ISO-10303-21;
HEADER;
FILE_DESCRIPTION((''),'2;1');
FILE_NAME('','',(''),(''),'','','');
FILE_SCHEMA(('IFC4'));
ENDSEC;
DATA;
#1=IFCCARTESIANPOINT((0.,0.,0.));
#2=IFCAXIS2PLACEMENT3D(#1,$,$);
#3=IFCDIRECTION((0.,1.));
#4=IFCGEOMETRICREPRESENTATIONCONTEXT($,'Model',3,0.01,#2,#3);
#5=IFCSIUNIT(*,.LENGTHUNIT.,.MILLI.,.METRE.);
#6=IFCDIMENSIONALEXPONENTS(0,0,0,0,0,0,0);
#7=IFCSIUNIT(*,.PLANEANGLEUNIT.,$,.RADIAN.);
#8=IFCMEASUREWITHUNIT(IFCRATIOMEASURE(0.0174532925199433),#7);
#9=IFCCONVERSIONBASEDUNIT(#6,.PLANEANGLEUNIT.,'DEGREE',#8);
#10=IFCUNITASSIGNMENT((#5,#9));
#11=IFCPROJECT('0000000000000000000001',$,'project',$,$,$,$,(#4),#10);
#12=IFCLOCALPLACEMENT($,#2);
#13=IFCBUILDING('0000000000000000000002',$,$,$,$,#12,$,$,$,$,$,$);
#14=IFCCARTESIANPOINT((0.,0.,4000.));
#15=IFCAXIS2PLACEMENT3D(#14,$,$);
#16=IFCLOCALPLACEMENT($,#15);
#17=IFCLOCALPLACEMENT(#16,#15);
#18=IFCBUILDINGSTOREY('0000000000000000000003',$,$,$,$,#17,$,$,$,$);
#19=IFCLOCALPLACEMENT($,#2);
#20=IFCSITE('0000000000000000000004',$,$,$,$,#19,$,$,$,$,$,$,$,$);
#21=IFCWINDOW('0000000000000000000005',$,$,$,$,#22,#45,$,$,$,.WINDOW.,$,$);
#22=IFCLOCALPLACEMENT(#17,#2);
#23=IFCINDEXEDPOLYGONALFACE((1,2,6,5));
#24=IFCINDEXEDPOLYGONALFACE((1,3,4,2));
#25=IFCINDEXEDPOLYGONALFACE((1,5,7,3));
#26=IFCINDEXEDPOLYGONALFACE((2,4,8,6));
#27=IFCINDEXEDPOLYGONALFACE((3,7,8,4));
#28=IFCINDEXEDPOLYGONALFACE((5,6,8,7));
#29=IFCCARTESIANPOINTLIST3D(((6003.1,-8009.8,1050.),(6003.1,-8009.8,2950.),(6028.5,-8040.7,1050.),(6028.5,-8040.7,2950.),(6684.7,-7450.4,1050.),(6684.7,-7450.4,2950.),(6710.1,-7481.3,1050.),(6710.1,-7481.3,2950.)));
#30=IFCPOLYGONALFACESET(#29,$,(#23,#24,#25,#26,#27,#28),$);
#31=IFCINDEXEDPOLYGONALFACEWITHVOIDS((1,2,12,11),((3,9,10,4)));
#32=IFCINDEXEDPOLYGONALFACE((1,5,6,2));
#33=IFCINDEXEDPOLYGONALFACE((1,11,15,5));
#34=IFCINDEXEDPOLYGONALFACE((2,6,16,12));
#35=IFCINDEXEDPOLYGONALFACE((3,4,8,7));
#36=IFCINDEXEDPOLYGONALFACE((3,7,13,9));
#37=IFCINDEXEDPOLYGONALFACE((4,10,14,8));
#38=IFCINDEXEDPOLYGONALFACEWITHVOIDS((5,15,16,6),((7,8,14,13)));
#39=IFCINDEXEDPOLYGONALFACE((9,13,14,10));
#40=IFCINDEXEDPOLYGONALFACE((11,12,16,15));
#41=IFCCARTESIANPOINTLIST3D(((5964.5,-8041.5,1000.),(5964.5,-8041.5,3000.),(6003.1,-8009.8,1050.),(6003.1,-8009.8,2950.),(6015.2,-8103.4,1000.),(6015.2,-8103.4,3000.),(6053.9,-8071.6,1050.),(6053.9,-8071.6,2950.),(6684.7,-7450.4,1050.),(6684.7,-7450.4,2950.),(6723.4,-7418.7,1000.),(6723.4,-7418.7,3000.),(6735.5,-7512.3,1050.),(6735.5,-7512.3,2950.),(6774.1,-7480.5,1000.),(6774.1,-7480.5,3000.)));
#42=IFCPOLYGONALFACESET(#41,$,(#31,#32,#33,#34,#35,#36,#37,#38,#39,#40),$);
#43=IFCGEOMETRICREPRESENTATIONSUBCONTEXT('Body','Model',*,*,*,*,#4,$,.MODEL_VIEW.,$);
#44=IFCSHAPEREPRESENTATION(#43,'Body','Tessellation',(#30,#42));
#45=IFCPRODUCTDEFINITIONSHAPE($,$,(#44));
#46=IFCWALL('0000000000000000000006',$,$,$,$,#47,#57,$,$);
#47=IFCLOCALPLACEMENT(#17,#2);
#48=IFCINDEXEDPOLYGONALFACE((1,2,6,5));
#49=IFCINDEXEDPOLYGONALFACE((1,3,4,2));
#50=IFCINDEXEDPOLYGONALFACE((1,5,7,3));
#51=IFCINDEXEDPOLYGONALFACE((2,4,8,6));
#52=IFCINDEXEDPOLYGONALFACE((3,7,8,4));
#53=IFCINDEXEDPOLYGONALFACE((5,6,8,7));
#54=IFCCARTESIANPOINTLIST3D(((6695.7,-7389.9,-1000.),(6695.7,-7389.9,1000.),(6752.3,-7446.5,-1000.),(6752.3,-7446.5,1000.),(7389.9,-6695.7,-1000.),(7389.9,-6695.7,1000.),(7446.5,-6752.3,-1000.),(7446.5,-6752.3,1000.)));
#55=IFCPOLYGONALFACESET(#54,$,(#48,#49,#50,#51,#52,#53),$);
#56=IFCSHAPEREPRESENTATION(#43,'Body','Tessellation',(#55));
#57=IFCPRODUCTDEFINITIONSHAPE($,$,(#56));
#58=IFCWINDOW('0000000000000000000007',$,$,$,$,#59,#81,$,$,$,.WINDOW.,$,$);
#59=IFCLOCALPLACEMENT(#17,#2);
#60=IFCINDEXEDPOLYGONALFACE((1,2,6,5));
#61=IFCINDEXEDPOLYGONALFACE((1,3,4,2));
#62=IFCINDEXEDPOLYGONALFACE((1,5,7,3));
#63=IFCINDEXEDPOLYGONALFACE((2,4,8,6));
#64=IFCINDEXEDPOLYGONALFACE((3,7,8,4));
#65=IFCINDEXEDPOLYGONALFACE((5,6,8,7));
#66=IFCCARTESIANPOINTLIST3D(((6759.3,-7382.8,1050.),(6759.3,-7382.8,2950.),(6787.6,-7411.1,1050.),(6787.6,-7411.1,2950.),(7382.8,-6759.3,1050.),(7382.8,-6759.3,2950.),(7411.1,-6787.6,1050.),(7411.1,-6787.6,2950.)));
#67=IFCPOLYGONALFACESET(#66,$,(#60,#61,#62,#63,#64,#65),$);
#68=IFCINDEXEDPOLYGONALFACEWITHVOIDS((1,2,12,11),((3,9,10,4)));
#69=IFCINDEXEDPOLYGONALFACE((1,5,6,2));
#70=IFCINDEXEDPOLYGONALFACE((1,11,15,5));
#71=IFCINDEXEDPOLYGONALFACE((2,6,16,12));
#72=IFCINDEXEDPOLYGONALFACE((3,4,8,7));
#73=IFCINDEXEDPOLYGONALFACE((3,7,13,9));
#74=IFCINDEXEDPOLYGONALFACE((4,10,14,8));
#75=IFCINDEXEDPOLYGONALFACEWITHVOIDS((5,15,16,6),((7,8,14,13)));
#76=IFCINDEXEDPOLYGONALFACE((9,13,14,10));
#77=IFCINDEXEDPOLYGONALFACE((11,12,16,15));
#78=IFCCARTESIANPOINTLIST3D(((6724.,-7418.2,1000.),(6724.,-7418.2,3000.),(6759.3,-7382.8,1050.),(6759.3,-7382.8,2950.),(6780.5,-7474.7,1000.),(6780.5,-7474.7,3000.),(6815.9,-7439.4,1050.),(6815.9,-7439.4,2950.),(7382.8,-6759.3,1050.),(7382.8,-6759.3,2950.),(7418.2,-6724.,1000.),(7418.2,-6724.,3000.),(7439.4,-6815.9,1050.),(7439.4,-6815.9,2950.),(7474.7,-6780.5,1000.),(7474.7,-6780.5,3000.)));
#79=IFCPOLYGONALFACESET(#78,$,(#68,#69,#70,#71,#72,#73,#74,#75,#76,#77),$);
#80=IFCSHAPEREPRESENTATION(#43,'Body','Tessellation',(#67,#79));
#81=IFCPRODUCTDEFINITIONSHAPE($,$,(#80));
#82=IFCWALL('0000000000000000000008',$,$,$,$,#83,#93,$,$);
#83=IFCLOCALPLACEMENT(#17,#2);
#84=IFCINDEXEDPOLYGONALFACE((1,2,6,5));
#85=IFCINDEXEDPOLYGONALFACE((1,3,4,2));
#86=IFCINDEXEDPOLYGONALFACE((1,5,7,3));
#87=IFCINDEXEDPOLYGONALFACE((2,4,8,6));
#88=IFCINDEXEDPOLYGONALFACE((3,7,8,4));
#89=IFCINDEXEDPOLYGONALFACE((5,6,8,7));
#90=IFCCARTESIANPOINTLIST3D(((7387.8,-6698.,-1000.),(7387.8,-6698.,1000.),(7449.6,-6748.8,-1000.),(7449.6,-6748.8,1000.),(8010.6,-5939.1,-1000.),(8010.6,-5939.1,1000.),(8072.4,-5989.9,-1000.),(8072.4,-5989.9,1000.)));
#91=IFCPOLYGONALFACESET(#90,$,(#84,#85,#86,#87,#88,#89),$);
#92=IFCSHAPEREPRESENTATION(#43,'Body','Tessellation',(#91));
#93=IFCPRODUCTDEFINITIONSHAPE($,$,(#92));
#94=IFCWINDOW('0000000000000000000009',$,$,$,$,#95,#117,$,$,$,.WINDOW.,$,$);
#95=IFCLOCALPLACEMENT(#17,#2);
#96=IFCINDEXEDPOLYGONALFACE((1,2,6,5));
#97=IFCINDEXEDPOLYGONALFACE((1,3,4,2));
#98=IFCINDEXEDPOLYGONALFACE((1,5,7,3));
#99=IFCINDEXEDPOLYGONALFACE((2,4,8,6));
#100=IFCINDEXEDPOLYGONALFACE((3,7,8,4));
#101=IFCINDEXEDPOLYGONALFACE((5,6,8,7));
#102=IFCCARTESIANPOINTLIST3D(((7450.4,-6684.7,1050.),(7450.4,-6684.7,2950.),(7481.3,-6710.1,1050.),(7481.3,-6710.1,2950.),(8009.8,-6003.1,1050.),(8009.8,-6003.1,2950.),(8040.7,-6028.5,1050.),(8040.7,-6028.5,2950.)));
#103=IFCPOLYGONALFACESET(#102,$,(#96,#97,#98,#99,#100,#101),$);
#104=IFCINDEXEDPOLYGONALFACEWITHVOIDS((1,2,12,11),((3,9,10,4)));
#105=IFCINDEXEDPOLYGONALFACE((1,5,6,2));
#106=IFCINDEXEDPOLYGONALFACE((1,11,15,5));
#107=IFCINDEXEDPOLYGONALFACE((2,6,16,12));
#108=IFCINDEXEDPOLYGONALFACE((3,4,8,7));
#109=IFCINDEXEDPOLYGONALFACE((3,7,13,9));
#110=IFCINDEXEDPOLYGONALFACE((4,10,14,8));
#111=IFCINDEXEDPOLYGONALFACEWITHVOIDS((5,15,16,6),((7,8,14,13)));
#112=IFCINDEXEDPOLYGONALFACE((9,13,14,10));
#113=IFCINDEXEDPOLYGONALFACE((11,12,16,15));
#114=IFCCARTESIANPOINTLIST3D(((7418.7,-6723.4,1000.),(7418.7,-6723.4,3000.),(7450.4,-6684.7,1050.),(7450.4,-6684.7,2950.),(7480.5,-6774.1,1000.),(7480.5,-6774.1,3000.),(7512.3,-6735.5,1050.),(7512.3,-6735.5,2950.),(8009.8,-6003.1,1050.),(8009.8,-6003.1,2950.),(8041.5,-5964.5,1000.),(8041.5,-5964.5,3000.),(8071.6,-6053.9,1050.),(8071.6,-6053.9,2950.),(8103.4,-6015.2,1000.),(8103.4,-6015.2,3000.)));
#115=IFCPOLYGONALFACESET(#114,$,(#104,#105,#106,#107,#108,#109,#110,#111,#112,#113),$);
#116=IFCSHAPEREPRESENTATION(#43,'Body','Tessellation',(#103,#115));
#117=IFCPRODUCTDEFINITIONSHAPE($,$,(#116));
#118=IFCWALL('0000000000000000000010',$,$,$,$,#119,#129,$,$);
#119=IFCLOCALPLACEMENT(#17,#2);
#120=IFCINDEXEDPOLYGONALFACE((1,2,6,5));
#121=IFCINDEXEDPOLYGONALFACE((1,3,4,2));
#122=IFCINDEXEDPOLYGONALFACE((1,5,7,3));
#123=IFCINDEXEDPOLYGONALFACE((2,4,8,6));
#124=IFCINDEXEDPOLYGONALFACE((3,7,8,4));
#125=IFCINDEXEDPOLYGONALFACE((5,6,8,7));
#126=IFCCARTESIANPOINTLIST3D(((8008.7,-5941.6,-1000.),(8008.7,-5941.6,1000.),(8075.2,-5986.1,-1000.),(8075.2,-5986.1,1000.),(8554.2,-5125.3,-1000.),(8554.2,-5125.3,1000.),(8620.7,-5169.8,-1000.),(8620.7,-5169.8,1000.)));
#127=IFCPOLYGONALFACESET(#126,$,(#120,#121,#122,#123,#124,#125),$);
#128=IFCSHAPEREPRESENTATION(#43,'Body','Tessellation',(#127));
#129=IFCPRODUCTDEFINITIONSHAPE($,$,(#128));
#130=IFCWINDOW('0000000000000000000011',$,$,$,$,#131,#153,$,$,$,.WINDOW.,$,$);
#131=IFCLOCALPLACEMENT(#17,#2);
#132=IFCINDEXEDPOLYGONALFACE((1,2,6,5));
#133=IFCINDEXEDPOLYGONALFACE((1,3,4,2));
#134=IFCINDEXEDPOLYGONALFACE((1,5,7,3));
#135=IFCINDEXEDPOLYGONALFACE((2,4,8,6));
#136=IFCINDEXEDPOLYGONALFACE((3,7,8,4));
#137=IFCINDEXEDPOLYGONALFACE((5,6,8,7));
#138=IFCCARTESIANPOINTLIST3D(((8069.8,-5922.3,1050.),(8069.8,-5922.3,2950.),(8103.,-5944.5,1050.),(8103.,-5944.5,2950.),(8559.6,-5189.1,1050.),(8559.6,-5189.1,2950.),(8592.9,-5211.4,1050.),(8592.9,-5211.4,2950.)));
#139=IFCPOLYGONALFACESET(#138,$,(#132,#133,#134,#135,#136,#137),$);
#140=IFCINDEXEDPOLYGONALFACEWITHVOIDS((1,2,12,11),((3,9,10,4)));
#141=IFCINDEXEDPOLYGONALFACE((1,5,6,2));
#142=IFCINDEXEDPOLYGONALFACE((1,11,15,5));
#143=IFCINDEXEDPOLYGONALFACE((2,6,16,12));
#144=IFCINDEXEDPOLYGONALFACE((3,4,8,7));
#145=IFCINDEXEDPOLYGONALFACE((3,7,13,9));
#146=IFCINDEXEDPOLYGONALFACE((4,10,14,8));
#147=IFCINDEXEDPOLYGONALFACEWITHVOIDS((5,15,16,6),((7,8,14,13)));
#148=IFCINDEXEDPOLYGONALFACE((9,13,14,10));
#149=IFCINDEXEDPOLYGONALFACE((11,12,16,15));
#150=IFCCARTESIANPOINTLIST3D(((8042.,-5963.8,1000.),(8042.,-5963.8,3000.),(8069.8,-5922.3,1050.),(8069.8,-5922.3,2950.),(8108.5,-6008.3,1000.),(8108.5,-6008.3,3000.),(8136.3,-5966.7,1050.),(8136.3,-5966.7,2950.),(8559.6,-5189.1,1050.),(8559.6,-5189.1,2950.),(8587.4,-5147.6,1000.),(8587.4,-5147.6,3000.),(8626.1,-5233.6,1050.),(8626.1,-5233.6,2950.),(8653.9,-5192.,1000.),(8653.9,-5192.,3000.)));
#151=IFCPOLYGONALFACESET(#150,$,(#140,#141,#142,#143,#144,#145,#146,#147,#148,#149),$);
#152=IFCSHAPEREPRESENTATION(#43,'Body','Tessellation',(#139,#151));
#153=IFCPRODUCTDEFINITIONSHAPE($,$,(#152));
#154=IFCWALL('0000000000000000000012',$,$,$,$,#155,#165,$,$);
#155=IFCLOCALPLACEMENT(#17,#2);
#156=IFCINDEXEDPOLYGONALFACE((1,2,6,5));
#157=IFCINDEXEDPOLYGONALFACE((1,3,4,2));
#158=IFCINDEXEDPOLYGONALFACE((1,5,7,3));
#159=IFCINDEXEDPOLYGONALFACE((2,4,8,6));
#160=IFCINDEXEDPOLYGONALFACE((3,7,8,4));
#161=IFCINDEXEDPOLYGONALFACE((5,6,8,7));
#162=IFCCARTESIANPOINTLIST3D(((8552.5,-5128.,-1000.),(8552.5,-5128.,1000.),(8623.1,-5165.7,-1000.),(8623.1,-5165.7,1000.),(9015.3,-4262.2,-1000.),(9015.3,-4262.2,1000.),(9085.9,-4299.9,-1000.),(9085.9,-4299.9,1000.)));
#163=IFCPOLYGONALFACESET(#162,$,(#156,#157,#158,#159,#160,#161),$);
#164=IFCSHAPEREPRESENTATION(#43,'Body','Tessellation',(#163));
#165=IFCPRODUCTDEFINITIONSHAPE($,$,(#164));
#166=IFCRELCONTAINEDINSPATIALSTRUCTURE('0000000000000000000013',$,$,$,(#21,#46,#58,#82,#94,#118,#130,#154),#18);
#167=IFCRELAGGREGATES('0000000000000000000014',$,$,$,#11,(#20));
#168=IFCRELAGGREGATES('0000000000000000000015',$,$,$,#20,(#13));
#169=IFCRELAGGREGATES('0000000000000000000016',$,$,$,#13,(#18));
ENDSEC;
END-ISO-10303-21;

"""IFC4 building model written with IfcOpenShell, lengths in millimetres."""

from ifc_helpers import new_model, entity, si_unit, converted_unit, direction, frame, origin, origin_2d, place, context, subcontext, project, spatial, rectangle, extrude, element, save


model = new_model("IFC4")

# Units and contexts
model_context = context("Model", 3, precision=0.01, world=origin(), true_north=direction((0.0, 1.0)))
body_context = subcontext(model_context, "Body", "Model", "MODEL_VIEW")
ifc_project = project(units=[si_unit("LENGTHUNIT", "METRE", prefix="MILLI"), converted_unit("PLANEANGLEUNIT", "DEGREE", entity("IfcRatioMeasure", 0.0174532925199433), si_unit("PLANEANGLEUNIT", "RADIAN"), dimensions=[0, 0, 0, 0, 0, 0, 0])], contexts=[model_context])

# Site, building, storey
site_placement = place(None, origin())
site = spatial("IfcSite", under=ifc_project, at=site_placement)
building_placement = place(None, origin())
building = spatial("IfcBuilding", under=site, at=building_placement)
placement = place(None, frame((0.0, 0.0, 4000.0)))
storey_placement = place(placement, frame((0.0, 0.0, 4000.0)))
storey = spatial("IfcBuildingStorey", under=building, at=storey_placement)

# Shared definitions
cartesian_point_1 = entity("IfcCartesianPoint", [-440.9, -950.0])
shared_polyline = entity("IfcPolyline", [cartesian_point_1, entity("IfcCartesianPoint", [-440.9, 950.0]), entity("IfcCartesianPoint", [-440.9, 950.0]), entity("IfcCartesianPoint", [440.9, 950.0]), entity("IfcCartesianPoint", [440.9, 950.0]), entity("IfcCartesianPoint", [440.9, -950.0]), entity("IfcCartesianPoint", [440.9, -950.0]), entity("IfcCartesianPoint", [-440.9, -950.0]), cartesian_point_1])

# Window
window_1_placement = place(storey_placement, frame((6343.9, -7730.1, 2000.0), z_axis=(0.0, 0.0, 1.0), x_axis=(7730.104195, 6343.933254, 0.0)))
cartesian_point_2 = entity("IfcCartesianPoint", [-490.9, -1000.0])
element("IfcWindow", 1, at=window_1_placement, inside=storey, PredefinedType="WINDOW", context=body_context, shape_type="SweptSolid", body=[
    entity("IfcExtrudedAreaSolid", entity("IfcArbitraryClosedProfileDef", "AREA", None, shared_polyline), entity("IfcAxis2Placement3D", entity("IfcCartesianPoint", [0.0, 0.0, 0.0]), entity("IfcDirection", [0.0, -1.0, 0.0]), entity("IfcDirection", [1.0, 0.0, 0.0])), entity("IfcDirection", [0.0, 0.0, 1.0]), 40.0),
    entity("IfcExtrudedAreaSolid", entity("IfcArbitraryProfileDefWithVoids", "AREA", None, entity("IfcPolyline", [cartesian_point_2, entity("IfcCartesianPoint", [-490.9, 1000.0]), entity("IfcCartesianPoint", [-490.9, 1000.0]), entity("IfcCartesianPoint", [490.9, 1000.0]), entity("IfcCartesianPoint", [490.9, 1000.0]), entity("IfcCartesianPoint", [490.9, -1000.0]), entity("IfcCartesianPoint", [490.9, -1000.0]), entity("IfcCartesianPoint", [-490.9, -1000.0]), cartesian_point_2]), [shared_polyline]), entity("IfcAxis2Placement3D", entity("IfcCartesianPoint", [0.0, 0.0, 0.0]), entity("IfcDirection", [0.0, -1.0, 0.0]), entity("IfcDirection", [1.0, 0.0, 0.0])), entity("IfcDirection", [0.0, 0.0, 1.0]), 80.0),
])

# Wall
wall_1_placement = place(storey_placement, frame((7071.1, -7071.1, -1000.0), z_axis=(0.0, 0.0, 1.0), x_axis=(7071.068837, 7071.066786, 0.0)))
element("IfcWall", 2, at=wall_1_placement, inside=storey, context=body_context, shape_type="SweptSolid", body=[
    extrude(rectangle(XDim=981.7, YDim=80.0, at=origin_2d()), origin(), (0.0, 0.0, 1.0), 2000.0),
])

# Window
window_2_placement = place(storey_placement, frame((7071.1, -7071.1, 2000.0), z_axis=(0.0, 0.0, 1.0), x_axis=(7071.068837, 7071.066786, 0.0)))
cartesian_point_3 = entity("IfcCartesianPoint", [-490.9, -1000.0])
element("IfcWindow", 3, at=window_2_placement, inside=storey, PredefinedType="WINDOW", context=body_context, shape_type="SweptSolid", body=[
    entity("IfcExtrudedAreaSolid", entity("IfcArbitraryClosedProfileDef", "AREA", None, shared_polyline), entity("IfcAxis2Placement3D", entity("IfcCartesianPoint", [0.0, 0.0, 0.0]), entity("IfcDirection", [0.0, -1.0, 0.0]), entity("IfcDirection", [1.0, 0.0, 0.0])), entity("IfcDirection", [0.0, 0.0, 1.0]), 40.0),
    entity("IfcExtrudedAreaSolid", entity("IfcArbitraryProfileDefWithVoids", "AREA", None, entity("IfcPolyline", [cartesian_point_3, entity("IfcCartesianPoint", [-490.9, 1000.0]), entity("IfcCartesianPoint", [-490.9, 1000.0]), entity("IfcCartesianPoint", [490.9, 1000.0]), entity("IfcCartesianPoint", [490.9, 1000.0]), entity("IfcCartesianPoint", [490.9, -1000.0]), entity("IfcCartesianPoint", [490.9, -1000.0]), entity("IfcCartesianPoint", [-490.9, -1000.0]), cartesian_point_3]), [shared_polyline]), entity("IfcAxis2Placement3D", entity("IfcCartesianPoint", [0.0, 0.0, 0.0]), entity("IfcDirection", [0.0, -1.0, 0.0]), entity("IfcDirection", [1.0, 0.0, 0.0])), entity("IfcDirection", [0.0, 0.0, 1.0]), 80.0),
])

# Wall
wall_2_placement = place(storey_placement, frame((7730.1, -6343.9, -1000.0), z_axis=(0.0, 0.0, 1.0), x_axis=(6343.931811, 7730.10538, 0.0)))
element("IfcWall", 4, at=wall_2_placement, inside=storey, context=body_context, shape_type="SweptSolid", body=[
    extrude(rectangle(XDim=981.7, YDim=80.0, at=origin_2d()), origin(), (0.0, 0.0, 1.0), 2000.0),
])

# Window
window_3_placement = place(storey_placement, frame((7730.1, -6343.9, 2000.0), z_axis=(0.0, 0.0, 1.0), x_axis=(6343.931811, 7730.10538, 0.0)))
cartesian_point_4 = entity("IfcCartesianPoint", [-490.9, -1000.0])
element("IfcWindow", 5, at=window_3_placement, inside=storey, PredefinedType="WINDOW", context=body_context, shape_type="SweptSolid", body=[
    entity("IfcExtrudedAreaSolid", entity("IfcArbitraryClosedProfileDef", "AREA", None, shared_polyline), entity("IfcAxis2Placement3D", entity("IfcCartesianPoint", [0.0, 0.0, 0.0]), entity("IfcDirection", [0.0, -1.0, 0.0]), entity("IfcDirection", [1.0, 0.0, 0.0])), entity("IfcDirection", [0.0, 0.0, 1.0]), 40.0),
    entity("IfcExtrudedAreaSolid", entity("IfcArbitraryProfileDefWithVoids", "AREA", None, entity("IfcPolyline", [cartesian_point_4, entity("IfcCartesianPoint", [-490.9, 1000.0]), entity("IfcCartesianPoint", [-490.9, 1000.0]), entity("IfcCartesianPoint", [490.9, 1000.0]), entity("IfcCartesianPoint", [490.9, 1000.0]), entity("IfcCartesianPoint", [490.9, -1000.0]), entity("IfcCartesianPoint", [490.9, -1000.0]), entity("IfcCartesianPoint", [-490.9, -1000.0]), cartesian_point_4]), [shared_polyline]), entity("IfcAxis2Placement3D", entity("IfcCartesianPoint", [0.0, 0.0, 0.0]), entity("IfcDirection", [0.0, -1.0, 0.0]), entity("IfcDirection", [1.0, 0.0, 0.0])), entity("IfcDirection", [0.0, 0.0, 1.0]), 80.0),
])

# Wall
wall_3_placement = place(storey_placement, frame((8314.7, -5555.7, -1000.0), z_axis=(0.0, 0.0, 1.0), x_axis=(5555.702871, 8314.695762, 0.0)))
element("IfcWall", 6, at=wall_3_placement, inside=storey, context=body_context, shape_type="SweptSolid", body=[
    extrude(rectangle(XDim=981.7, YDim=80.0, at=origin_2d()), origin(), (0.0, 0.0, 1.0), 2000.0),
])

# Window
window_4_placement = place(storey_placement, frame((8314.7, -5555.7, 2000.0), z_axis=(0.0, 0.0, 1.0), x_axis=(5555.702871, 8314.695762, 0.0)))
cartesian_point_5 = entity("IfcCartesianPoint", [-490.9, -1000.0])
element("IfcWindow", 7, at=window_4_placement, inside=storey, PredefinedType="WINDOW", context=body_context, shape_type="SweptSolid", body=[
    entity("IfcExtrudedAreaSolid", entity("IfcArbitraryClosedProfileDef", "AREA", None, shared_polyline), entity("IfcAxis2Placement3D", entity("IfcCartesianPoint", [0.0, 0.0, 0.0]), entity("IfcDirection", [0.0, -1.0, 0.0]), entity("IfcDirection", [1.0, 0.0, 0.0])), entity("IfcDirection", [0.0, 0.0, 1.0]), 40.0),
    entity("IfcExtrudedAreaSolid", entity("IfcArbitraryProfileDefWithVoids", "AREA", None, entity("IfcPolyline", [cartesian_point_5, entity("IfcCartesianPoint", [-490.9, 1000.0]), entity("IfcCartesianPoint", [-490.9, 1000.0]), entity("IfcCartesianPoint", [490.9, 1000.0]), entity("IfcCartesianPoint", [490.9, 1000.0]), entity("IfcCartesianPoint", [490.9, -1000.0]), entity("IfcCartesianPoint", [490.9, -1000.0]), entity("IfcCartesianPoint", [-490.9, -1000.0]), cartesian_point_5]), [shared_polyline]), entity("IfcAxis2Placement3D", entity("IfcCartesianPoint", [0.0, 0.0, 0.0]), entity("IfcDirection", [0.0, -1.0, 0.0]), entity("IfcDirection", [1.0, 0.0, 0.0])), entity("IfcDirection", [0.0, 0.0, 1.0]), 80.0),
])

# Wall
wall_4_placement = place(storey_placement, frame((8819.2, -4714.0, -1000.0), z_axis=(0.0, 0.0, 1.0), x_axis=(4713.965487, 8819.213649, 0.0)))
element("IfcWall", 8, at=wall_4_placement, inside=storey, context=body_context, shape_type="SweptSolid", body=[
    extrude(rectangle(XDim=981.7, YDim=80.0, at=origin_2d()), origin(), (0.0, 0.0, 1.0), 2000.0),
])

save(model, "model.ifc")
